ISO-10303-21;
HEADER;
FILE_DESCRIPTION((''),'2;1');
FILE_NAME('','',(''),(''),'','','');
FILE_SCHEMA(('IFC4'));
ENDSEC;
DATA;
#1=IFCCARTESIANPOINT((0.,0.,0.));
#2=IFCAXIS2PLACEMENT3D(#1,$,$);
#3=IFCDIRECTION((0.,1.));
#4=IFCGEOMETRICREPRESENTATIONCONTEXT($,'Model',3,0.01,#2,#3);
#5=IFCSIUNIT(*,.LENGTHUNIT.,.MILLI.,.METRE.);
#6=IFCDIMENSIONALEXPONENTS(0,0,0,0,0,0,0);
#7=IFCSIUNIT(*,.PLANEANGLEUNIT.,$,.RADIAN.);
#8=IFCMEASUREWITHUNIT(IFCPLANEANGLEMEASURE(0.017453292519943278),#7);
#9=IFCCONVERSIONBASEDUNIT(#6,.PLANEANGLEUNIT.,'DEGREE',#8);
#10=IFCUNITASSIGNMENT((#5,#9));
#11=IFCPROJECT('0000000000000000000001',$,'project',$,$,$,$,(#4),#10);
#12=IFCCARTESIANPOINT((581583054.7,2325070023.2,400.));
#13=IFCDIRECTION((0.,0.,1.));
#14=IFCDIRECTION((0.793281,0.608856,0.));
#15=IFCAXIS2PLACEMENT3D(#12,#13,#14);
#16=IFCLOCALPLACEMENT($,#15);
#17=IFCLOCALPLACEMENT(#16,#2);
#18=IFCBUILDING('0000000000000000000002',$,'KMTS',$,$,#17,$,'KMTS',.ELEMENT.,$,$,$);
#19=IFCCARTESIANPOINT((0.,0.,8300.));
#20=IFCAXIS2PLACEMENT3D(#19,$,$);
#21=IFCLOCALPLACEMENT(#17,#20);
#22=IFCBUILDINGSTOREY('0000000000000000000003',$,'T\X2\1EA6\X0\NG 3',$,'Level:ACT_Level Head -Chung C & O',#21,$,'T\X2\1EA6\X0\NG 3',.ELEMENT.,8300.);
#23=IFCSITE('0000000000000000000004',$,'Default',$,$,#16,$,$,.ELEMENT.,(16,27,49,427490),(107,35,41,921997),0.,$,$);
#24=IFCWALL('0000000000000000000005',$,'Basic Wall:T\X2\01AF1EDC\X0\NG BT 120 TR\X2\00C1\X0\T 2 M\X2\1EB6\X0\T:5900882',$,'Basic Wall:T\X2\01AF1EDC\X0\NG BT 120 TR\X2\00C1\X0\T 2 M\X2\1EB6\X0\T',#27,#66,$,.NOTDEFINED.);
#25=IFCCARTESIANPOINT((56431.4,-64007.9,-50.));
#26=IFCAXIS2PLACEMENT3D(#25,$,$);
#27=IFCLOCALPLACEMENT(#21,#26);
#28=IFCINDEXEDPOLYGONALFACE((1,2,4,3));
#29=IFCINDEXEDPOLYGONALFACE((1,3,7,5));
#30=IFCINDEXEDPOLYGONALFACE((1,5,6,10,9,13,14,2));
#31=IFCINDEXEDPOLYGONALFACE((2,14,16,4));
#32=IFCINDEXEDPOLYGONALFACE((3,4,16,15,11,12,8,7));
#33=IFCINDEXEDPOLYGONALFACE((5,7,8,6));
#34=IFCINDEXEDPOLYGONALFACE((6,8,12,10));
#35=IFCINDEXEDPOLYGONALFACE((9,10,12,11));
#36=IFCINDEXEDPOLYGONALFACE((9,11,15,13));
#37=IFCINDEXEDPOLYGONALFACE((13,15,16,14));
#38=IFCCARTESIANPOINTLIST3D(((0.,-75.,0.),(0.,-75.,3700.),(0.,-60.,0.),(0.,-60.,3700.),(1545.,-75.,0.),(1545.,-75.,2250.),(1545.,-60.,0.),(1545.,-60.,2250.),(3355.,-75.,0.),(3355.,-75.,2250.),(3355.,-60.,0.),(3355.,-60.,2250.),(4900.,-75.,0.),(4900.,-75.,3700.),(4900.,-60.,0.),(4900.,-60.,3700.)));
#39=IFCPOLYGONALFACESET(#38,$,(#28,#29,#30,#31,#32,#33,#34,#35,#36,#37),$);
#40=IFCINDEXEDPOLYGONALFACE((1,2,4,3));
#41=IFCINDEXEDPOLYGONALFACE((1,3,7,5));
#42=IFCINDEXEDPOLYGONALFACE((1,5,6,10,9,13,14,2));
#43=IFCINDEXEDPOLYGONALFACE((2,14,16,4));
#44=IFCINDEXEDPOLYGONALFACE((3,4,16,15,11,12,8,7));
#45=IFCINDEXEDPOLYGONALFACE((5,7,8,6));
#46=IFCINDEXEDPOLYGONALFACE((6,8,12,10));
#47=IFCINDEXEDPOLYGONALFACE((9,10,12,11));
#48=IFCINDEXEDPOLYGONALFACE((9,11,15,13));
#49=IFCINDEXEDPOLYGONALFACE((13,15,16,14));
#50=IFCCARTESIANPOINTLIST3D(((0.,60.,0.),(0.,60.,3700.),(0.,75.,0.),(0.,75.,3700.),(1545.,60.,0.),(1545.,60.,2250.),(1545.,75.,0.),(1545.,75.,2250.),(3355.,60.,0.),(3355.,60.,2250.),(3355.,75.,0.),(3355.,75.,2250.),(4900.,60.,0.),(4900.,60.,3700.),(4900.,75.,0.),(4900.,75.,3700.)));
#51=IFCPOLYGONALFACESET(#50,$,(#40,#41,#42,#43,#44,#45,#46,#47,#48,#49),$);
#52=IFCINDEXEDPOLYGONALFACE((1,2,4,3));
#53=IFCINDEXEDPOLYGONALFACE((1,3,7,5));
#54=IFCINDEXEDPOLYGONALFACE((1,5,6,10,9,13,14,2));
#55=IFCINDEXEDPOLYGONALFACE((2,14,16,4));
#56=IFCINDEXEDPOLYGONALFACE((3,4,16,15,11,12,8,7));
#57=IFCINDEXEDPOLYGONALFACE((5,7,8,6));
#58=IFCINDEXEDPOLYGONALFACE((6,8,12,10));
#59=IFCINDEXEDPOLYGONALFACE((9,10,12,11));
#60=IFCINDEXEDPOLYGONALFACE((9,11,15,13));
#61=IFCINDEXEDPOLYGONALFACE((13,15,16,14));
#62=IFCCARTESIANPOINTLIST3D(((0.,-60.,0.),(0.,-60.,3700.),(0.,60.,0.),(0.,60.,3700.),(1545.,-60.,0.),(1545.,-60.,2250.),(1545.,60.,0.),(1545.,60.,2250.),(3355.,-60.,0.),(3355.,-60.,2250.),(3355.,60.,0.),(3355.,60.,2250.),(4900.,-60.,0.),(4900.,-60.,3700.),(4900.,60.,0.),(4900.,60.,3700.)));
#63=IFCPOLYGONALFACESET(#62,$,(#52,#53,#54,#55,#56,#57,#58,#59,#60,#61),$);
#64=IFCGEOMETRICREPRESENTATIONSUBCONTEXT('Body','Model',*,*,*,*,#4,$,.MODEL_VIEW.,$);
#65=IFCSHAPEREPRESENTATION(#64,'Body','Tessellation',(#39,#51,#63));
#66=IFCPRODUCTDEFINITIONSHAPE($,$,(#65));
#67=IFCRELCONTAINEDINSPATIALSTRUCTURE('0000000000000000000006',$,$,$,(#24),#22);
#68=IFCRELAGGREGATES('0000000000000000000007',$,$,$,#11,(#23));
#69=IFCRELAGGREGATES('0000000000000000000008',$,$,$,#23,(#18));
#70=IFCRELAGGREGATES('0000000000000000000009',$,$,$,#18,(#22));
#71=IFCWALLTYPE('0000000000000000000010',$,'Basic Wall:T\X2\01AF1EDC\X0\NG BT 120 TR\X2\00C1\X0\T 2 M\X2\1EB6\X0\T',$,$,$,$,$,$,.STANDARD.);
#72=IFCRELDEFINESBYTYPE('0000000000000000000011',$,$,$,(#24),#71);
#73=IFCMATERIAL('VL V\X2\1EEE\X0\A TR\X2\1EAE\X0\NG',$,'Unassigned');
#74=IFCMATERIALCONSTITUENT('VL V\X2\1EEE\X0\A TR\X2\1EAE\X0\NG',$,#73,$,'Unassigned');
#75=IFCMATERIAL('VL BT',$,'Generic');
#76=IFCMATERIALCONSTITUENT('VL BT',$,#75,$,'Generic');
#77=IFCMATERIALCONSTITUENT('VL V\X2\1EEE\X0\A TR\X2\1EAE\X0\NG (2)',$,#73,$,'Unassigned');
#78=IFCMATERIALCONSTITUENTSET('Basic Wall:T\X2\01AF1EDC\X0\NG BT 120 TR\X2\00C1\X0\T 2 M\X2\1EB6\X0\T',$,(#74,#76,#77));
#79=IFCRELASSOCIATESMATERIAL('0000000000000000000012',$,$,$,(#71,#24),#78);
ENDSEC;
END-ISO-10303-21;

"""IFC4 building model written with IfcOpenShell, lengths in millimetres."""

from ifc_helpers import new_model, entity, si_unit, converted_unit, direction, frame, origin, place, context, subcontext, project, spatial, indexed_curve, outline, extrude, material, constituent, constituent_set, type_object, element, save


model = new_model("IFC4")

# Units and contexts
model_context = context("Model", 3, precision=0.01, world=origin(), true_north=direction((0.0, 1.0)))
body_context = subcontext(model_context, "Body", "Model", "MODEL_VIEW")
ifc_project = project(units=[si_unit("LENGTHUNIT", "METRE", prefix="MILLI"), converted_unit("PLANEANGLEUNIT", "DEGREE", entity("IfcPlaneAngleMeasure", 0.017453292519943278), si_unit("PLANEANGLEUNIT", "RADIAN"), dimensions=[0, 0, 0, 0, 0, 0, 0])], contexts=[model_context])

# Site, building, storey
site_placement = place(None, frame((581583054.7, 2325070023.2, 400.0), z_axis=(0.0, 0.0, 1.0), x_axis=(0.793281, 0.608856, 0.0)))
site = spatial("IfcSite", under=ifc_project, at=site_placement, Name="Default", CompositionType="ELEMENT", RefLatitude=(16, 27, 49, 427490), RefLongitude=(107, 35, 41, 921997), RefElevation=0.0)
building_placement = place(site_placement, origin())
building = spatial("IfcBuilding", under=site, at=building_placement, Name="KMTS", LongName="KMTS", CompositionType="ELEMENT")
storey_placement = place(building_placement, frame((0.0, 0.0, 8300.0)))
storey = spatial("IfcBuildingStorey", under=building, at=storey_placement, Name="TẦNG 3", ObjectType="Level:ACT_Level Head -Chung C & O", LongName="TẦNG 3", CompositionType="ELEMENT", Elevation=8300.0)

# Shared definitions
ifc_material_1 = material(Name="VL VỮA TRẮNG", Category="Unassigned")
ifc_material_2 = material(Name="VL BT", Category="Generic")

# Wall, opening
ifc_constituent_1 = constituent(ifc_material_1, Name="VL VỮA TRẮNG", Category="Unassigned")
ifc_constituent_2 = constituent(ifc_material_2, Name="VL BT", Category="Generic")
ifc_constituent_3 = constituent(ifc_material_1, Name="VL VỮA TRẮNG (2)", Category="Unassigned")
ifc_constituent_set_1 = constituent_set(constituents=[ifc_constituent_1, ifc_constituent_2, ifc_constituent_3], Name="Basic Wall:TƯỜNG BT 120 TRÁT 2 MẶT")
wall_type_1 = type_object("IfcWallType", Name="Basic Wall:TƯỜNG BT 120 TRÁT 2 MẶT", PredefinedType="STANDARD", material=ifc_constituent_set_1)
wall_1_placement = place(storey_placement, frame((56431.4, -64007.9, -50.0)))
wall_1 = element("IfcWall", 1, at=wall_1_placement, inside=storey, type_object=wall_type_1, material=ifc_constituent_set_1, Name="Basic Wall:TƯỜNG BT 120 TRÁT 2 MẶT:5900882", ObjectType="Basic Wall:TƯỜNG BT 120 TRÁT 2 MẶT", PredefinedType="NOTDEFINED", context=body_context, shape_type="SweptSolid", body=[
    extrude(outline(indexed_curve([(-2450.0, -1487.5), (-905.0, -1487.5), (-905.0, 762.5), (905.0, 762.5), (905.0, -1487.5), (2450.0, -1487.5), (2450.0, 2212.5), (-2450.0, 2212.5), (-2450.0, -1487.5)], self_intersect=False)), frame((2450.0, -75.0, 1487.5), z_axis=(0.0, 1.0, 0.0), x_axis=(-1.0, 0.0, 0.0)), (0.0, 0.0, 1.0), 15.0),
    extrude(outline(indexed_curve([(-1487.5, -905.0), (-1487.5, -2450.0), (2212.5, -2450.0), (2212.5, 2450.0), (-1487.5, 2450.0), (-1487.5, 905.0), (762.5, 905.0), (762.5, -905.0), (-1487.5, -905.0)], self_intersect=False)), frame((2450.0, 60.0, 1487.5), z_axis=(0.0, -1.0, 0.0), x_axis=(0.0, 0.0, 1.0)), (0.0, 0.0, -1.0), 15.0),
    extrude(outline(indexed_curve([(-1487.5, -905.0), (-1487.5, -2450.0), (2212.5, -2450.0), (2212.5, 2450.0), (-1487.5, 2450.0), (-1487.5, 905.0), (762.5, 905.0), (762.5, -905.0), (-1487.5, -905.0)], self_intersect=False)), frame((2450.0, -60.0, 1487.5), z_axis=(0.0, -1.0, 0.0), x_axis=(0.0, 0.0, 1.0)), (0.0, 0.0, -1.0), 120.0),
])
opening_1_placement = place(wall_1_placement, frame((1545.0, -75.0, 0.0)))
element("IfcOpeningElement", 2, at=opening_1_placement, cuts=wall_1, PredefinedType="OPENING", context=body_context, shape_type="SweptSolid", body=[
    extrude(outline(indexed_curve([(2250.0, 0.0), (2250.0, 1810.0), (0.0, 1810.0), (0.0, 0.0), (2250.0, 0.0)], self_intersect=False)), frame((0.0, 0.0, 0.0), z_axis=(0.0, 1.0, 0.0), x_axis=(0.0, 0.0, 1.0)), (0.0, 0.0, 1.0), 150.0),
])

save(model, "model.ifc")
